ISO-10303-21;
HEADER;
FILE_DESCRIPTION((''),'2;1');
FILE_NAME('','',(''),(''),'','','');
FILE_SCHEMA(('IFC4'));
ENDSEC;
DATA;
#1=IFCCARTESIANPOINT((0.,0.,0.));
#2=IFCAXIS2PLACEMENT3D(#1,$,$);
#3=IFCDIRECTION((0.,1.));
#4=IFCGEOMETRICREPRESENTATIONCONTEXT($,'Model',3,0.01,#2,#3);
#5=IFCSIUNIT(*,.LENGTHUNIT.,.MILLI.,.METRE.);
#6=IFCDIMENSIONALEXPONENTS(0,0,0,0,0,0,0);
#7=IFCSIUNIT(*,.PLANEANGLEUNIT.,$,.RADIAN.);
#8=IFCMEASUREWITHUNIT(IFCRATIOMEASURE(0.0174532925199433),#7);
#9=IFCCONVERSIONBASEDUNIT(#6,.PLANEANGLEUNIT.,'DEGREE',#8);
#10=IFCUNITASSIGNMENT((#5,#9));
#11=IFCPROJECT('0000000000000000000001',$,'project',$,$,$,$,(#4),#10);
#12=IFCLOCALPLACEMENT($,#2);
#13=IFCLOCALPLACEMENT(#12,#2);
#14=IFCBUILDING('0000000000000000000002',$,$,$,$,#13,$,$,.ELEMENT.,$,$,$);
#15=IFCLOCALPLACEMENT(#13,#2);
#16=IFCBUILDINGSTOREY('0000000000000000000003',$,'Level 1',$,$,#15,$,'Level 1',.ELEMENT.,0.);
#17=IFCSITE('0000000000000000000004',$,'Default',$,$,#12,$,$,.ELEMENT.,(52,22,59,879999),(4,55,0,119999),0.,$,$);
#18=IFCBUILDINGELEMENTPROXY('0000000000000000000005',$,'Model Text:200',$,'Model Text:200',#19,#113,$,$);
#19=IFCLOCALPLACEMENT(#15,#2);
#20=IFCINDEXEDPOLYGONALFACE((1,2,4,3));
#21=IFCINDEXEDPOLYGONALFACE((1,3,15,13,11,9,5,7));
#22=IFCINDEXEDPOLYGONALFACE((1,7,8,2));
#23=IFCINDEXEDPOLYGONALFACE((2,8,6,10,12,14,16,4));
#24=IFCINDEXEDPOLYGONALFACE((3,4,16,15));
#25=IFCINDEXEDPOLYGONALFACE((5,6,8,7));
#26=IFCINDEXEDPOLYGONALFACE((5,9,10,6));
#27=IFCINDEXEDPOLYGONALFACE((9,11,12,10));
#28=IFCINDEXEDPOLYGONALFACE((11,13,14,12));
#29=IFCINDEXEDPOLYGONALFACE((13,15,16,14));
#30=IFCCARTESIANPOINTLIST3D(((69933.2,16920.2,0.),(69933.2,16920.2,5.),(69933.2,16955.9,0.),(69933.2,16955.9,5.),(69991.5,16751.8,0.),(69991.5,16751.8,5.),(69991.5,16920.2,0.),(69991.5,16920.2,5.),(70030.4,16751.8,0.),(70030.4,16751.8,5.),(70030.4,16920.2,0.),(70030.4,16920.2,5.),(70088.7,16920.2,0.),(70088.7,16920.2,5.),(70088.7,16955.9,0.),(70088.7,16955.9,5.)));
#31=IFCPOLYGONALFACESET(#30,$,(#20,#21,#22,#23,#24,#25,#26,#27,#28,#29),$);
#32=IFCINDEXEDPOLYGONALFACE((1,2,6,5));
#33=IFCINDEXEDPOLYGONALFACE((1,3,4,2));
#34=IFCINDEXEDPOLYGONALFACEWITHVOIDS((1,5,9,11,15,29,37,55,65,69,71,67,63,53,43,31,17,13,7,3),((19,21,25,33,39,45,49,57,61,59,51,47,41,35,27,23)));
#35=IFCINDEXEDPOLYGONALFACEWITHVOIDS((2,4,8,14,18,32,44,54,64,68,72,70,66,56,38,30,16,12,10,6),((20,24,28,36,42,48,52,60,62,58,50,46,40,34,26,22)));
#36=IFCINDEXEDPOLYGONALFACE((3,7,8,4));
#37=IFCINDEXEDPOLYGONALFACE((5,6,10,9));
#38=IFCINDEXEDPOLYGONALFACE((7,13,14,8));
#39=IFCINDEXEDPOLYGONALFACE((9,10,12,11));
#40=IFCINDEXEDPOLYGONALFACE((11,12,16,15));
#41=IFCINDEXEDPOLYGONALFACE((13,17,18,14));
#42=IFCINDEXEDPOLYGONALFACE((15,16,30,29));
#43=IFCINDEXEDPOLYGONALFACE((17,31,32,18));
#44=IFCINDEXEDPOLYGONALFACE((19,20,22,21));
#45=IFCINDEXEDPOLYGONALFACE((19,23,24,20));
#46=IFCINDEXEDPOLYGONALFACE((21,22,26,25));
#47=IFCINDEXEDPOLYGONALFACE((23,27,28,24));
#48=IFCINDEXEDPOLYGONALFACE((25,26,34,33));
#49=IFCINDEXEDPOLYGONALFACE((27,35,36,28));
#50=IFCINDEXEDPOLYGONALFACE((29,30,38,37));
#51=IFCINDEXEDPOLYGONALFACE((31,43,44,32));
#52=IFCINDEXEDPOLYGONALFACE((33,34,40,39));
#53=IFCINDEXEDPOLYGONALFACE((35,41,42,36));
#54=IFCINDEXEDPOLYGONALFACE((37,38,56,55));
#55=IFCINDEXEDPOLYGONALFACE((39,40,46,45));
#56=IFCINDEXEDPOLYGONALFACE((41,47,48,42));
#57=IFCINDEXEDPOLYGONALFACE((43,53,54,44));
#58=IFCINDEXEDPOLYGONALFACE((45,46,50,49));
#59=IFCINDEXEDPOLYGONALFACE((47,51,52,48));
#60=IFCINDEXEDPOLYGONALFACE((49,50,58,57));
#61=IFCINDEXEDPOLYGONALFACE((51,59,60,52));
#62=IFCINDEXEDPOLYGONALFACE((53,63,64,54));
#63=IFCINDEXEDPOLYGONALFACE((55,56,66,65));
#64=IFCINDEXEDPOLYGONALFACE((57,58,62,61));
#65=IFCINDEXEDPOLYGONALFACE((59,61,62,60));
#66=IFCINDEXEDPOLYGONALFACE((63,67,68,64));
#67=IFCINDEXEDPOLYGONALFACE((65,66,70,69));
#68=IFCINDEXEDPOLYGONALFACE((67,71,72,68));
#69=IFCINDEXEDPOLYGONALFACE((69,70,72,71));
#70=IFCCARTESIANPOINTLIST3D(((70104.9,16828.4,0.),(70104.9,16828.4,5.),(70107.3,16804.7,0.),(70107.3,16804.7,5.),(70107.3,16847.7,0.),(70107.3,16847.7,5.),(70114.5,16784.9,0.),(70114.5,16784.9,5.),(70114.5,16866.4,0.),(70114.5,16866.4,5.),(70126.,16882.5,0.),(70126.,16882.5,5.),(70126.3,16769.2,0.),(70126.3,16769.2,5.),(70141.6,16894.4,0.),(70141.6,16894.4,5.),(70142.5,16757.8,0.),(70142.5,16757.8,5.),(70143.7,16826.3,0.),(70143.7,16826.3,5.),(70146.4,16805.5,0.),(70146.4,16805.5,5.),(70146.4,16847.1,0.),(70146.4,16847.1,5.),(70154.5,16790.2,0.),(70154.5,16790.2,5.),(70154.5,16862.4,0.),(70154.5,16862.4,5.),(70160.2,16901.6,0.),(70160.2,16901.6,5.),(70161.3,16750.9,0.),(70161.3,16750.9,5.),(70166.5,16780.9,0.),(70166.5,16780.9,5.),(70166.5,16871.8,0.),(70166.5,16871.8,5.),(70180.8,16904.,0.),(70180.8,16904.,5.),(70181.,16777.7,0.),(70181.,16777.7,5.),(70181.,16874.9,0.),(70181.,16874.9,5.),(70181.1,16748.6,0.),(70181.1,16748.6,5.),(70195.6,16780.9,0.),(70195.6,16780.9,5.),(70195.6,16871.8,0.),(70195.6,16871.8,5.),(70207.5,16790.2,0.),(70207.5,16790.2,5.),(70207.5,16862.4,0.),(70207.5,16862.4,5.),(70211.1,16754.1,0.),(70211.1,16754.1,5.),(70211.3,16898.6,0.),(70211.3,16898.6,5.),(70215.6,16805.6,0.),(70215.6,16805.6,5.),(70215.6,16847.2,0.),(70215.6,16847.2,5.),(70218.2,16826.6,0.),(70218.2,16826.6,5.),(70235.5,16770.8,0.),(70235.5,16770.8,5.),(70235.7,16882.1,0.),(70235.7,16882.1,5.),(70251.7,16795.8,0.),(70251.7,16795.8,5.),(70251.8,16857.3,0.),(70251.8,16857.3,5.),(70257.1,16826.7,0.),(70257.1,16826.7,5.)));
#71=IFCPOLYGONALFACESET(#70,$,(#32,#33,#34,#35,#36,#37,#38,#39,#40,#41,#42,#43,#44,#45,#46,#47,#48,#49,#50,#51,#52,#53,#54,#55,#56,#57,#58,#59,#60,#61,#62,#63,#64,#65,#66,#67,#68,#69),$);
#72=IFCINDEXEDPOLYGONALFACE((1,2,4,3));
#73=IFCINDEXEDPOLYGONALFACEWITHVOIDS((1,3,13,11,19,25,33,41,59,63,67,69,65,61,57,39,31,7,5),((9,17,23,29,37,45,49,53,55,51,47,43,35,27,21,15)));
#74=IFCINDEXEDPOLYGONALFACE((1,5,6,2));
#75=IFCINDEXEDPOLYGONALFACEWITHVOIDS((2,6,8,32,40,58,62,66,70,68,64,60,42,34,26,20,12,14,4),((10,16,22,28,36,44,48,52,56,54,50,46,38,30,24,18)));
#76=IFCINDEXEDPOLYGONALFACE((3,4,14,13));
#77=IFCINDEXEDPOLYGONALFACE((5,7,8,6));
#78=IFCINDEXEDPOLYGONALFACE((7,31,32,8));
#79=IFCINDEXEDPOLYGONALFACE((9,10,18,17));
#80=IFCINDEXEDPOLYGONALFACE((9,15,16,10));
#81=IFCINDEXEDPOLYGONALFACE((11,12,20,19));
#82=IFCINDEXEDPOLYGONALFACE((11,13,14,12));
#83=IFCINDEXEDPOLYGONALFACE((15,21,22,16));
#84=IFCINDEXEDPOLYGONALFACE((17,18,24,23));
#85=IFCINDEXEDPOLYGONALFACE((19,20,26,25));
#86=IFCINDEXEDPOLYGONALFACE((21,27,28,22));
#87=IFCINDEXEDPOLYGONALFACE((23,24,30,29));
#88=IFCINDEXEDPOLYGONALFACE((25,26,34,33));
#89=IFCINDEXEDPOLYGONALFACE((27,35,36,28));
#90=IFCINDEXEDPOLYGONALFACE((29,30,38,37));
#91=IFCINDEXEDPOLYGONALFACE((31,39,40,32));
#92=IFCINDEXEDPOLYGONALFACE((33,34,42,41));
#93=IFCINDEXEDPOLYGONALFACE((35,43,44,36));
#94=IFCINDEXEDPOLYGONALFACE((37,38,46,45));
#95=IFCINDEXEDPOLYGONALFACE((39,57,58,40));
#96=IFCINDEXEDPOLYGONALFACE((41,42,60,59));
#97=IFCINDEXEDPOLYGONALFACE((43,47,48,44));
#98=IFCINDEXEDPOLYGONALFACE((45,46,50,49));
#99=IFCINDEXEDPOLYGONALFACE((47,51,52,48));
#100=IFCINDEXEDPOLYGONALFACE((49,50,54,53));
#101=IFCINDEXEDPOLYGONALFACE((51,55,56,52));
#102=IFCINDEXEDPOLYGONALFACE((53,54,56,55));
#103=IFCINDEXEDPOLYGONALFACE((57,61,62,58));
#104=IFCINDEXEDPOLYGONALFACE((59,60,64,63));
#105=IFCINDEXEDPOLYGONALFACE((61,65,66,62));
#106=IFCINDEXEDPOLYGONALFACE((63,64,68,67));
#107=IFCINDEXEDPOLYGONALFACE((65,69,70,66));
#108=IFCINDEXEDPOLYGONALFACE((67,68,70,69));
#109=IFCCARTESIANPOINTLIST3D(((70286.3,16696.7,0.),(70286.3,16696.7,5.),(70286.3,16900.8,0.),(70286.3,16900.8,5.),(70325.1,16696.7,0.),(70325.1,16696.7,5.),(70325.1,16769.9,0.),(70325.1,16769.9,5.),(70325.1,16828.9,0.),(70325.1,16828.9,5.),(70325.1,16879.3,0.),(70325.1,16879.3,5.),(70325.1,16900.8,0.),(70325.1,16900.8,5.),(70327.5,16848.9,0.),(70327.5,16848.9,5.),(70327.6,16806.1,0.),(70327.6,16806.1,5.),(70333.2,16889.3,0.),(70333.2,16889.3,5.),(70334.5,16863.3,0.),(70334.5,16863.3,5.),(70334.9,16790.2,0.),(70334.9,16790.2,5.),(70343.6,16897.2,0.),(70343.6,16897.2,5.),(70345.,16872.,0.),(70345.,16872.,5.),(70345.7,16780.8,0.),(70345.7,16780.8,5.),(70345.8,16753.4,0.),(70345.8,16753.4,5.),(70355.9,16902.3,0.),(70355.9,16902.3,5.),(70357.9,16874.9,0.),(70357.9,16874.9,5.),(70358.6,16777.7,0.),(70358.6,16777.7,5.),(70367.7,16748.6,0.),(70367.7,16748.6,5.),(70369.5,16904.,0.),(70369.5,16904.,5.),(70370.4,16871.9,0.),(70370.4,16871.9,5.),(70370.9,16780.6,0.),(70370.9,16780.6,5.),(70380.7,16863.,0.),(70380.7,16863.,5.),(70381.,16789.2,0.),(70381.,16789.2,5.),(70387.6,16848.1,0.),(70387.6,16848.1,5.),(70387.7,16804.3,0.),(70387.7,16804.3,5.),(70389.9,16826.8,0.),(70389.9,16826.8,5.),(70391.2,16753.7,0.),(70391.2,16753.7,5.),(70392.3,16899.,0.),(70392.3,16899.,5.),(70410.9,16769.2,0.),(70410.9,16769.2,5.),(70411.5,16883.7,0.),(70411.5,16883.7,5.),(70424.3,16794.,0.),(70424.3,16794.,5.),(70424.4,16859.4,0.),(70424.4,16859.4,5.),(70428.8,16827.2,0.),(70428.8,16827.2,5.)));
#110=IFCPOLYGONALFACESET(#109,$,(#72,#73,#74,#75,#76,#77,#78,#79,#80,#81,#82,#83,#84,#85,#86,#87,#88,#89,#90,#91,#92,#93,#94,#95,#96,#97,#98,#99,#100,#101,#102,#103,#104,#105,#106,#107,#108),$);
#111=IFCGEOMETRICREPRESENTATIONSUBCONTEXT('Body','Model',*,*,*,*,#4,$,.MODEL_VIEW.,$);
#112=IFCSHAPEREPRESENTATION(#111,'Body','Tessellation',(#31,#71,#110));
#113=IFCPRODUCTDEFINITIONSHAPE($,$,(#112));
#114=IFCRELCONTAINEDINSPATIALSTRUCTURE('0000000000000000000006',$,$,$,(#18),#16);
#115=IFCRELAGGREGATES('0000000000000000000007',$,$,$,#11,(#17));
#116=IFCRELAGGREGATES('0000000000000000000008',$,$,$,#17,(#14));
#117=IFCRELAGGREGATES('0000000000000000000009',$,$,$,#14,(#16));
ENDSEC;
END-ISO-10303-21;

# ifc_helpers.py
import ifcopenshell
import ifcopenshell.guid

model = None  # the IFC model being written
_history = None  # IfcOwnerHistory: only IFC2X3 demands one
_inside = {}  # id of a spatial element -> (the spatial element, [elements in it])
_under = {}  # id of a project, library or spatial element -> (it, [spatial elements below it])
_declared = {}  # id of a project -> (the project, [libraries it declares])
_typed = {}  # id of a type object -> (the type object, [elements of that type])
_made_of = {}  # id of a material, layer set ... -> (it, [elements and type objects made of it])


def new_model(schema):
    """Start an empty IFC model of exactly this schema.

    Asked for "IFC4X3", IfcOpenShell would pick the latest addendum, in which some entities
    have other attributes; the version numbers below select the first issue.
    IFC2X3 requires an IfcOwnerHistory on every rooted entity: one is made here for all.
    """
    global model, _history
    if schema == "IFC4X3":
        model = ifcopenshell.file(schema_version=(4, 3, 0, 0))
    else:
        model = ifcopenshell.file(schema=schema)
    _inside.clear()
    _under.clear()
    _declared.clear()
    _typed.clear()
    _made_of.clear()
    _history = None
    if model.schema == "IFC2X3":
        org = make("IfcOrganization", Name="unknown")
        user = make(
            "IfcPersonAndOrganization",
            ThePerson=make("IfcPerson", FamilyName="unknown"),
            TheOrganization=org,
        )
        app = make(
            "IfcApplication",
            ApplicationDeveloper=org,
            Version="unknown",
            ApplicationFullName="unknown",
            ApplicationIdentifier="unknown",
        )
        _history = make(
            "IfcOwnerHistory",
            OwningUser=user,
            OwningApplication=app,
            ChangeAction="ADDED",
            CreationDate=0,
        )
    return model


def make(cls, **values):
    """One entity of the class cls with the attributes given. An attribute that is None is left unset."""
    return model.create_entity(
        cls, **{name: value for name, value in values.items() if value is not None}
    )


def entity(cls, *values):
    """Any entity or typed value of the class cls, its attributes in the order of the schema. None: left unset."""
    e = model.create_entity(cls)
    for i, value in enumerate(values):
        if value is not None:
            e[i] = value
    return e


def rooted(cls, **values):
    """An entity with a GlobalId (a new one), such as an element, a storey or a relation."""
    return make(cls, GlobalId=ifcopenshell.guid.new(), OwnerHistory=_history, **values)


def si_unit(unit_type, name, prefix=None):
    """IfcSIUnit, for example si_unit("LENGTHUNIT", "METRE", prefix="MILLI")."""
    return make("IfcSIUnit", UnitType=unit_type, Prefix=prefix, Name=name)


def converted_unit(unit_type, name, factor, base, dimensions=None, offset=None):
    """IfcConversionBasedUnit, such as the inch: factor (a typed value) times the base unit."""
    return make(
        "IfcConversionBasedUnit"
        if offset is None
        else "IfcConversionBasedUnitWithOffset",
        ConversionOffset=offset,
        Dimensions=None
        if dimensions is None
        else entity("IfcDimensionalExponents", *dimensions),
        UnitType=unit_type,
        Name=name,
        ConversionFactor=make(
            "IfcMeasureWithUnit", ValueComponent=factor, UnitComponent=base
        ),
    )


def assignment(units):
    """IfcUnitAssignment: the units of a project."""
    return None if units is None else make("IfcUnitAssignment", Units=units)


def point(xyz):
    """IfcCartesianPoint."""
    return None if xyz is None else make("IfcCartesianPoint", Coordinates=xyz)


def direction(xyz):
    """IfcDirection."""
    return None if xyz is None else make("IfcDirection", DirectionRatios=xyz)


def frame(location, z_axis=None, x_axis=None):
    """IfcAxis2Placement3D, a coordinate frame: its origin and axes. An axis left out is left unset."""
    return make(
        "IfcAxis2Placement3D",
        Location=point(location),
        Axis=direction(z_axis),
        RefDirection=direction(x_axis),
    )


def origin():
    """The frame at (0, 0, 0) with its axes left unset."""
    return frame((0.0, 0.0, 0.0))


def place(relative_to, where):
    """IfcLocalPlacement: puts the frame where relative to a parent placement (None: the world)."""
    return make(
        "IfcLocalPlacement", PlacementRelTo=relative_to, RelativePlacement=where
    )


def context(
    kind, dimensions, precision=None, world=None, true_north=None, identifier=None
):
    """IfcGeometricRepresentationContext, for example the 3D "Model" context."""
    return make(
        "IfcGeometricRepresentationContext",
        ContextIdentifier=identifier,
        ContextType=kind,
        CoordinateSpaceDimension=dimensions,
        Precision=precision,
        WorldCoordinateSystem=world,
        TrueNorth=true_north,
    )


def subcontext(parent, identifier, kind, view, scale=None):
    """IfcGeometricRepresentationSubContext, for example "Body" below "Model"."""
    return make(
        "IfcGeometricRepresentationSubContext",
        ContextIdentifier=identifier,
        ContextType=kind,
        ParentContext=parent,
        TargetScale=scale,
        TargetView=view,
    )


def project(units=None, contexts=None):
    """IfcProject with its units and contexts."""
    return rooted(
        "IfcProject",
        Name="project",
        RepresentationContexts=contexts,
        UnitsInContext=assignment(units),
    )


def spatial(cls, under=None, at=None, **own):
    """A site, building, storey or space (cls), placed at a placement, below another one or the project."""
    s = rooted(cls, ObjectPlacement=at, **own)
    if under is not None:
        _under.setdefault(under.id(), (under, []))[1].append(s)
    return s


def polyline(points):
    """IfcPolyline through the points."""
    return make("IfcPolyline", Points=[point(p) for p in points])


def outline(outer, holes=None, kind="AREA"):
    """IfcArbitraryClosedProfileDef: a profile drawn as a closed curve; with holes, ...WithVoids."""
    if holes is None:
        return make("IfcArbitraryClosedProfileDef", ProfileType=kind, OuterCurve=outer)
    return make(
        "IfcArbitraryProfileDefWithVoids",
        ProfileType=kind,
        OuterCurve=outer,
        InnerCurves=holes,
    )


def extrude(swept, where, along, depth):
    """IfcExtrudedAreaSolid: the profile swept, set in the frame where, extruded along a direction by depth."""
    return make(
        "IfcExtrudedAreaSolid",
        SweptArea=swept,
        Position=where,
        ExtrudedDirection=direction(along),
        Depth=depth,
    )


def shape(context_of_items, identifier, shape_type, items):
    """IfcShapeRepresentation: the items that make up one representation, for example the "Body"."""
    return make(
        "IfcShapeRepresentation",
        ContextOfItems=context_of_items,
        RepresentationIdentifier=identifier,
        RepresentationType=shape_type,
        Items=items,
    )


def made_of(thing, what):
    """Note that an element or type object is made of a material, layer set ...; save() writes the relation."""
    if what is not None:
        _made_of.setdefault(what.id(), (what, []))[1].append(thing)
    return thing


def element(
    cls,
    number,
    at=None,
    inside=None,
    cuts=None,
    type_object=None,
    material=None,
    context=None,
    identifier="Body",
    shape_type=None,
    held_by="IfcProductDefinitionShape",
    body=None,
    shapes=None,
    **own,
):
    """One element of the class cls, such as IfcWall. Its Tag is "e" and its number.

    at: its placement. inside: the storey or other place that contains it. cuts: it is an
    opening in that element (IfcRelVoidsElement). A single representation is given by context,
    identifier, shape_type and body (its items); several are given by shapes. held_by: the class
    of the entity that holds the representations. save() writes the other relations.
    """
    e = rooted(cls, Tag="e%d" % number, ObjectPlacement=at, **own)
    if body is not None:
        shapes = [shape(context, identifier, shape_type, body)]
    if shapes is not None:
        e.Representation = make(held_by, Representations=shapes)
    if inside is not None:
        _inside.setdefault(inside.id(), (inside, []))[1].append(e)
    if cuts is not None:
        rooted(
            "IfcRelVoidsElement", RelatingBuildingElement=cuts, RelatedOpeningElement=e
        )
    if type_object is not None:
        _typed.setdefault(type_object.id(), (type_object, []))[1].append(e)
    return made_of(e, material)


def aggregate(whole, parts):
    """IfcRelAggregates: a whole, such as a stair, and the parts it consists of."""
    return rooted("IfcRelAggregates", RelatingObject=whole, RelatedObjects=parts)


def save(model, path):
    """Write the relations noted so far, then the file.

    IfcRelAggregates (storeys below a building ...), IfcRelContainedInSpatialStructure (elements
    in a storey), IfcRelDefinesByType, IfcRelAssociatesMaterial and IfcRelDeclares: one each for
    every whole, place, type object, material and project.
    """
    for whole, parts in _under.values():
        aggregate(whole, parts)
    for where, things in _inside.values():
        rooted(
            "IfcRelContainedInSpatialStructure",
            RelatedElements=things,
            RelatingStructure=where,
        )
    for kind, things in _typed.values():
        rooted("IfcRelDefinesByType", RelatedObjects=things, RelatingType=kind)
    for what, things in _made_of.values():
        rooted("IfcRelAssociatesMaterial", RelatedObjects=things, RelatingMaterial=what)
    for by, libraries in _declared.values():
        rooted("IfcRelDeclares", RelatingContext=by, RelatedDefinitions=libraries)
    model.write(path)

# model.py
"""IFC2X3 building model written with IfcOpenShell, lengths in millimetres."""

from ifc_helpers import new_model, entity, si_unit, converted_unit, direction, frame, origin, place, context, subcontext, project, spatial, polyline, outline, extrude, element, save


model = new_model("IFC2X3")

# Units and contexts
model_context = context("Model", 3, precision=0.01, world=origin(), true_north=direction((0.0, 1.0)))
body_context = subcontext(model_context, "Body", "Model", "MODEL_VIEW")
ifc_project = project(units=[si_unit("LENGTHUNIT", "METRE", prefix="MILLI"), converted_unit("PLANEANGLEUNIT", "DEGREE", entity("IfcRatioMeasure", 0.0174532925199433), si_unit("PLANEANGLEUNIT", "RADIAN"), dimensions=[0, 0, 0, 0, 0, 0, 0])], contexts=[model_context])

# Site, building, storey
site_placement = place(None, origin())
site = spatial("IfcSite", under=ifc_project, at=site_placement, Name="Default", CompositionType="ELEMENT", RefLatitude=(52, 22, 59, 879999), RefLongitude=(4, 55, 0, 119999), RefElevation=0.0)
building_placement = place(site_placement, origin())
building = spatial("IfcBuilding", under=site, at=building_placement, CompositionType="ELEMENT")
storey_placement = place(building_placement, origin())
storey = spatial("IfcBuildingStorey", under=building, at=storey_placement, Name="Level 1", LongName="Level 1", CompositionType="ELEMENT", Elevation=0.0)

# Building element proxy
proxy_1_placement = place(building_placement, origin())
element("IfcBuildingElementProxy", 1, at=proxy_1_placement, inside=storey, Name="Model Text:200", ObjectType="Model Text:200", context=body_context, shape_type="SweptSolid", body=[
    extrude(outline(polyline([(-19.4, -135.2), (19.4, -135.2), (19.4, 33.2), (77.7, 33.2), (77.7, 68.8), (-77.7, 68.8), (-77.7, 33.2), (-19.4, 33.2), (-19.4, -135.2)])), frame((70010.9, 16887.0, 0.0)), (0.0, 0.0, 1.0), 5.0),
    extrude(outline(polyline([(-8.8, -65.7), (15.1, -65.7), (35.5, -60.5), (52.3, -50.4), (65.3, -35.4), (74.1, -17.3), (78.4, 2.1), (75.9, 32.5), (61.8, 58.5), (38.4, 77.1), (8.3, 85.6), (-22.7, 83.3), (-49.0, 69.9), (-67.8, 47.3), (-76.3, 17.5), (-76.0, -3.3), (-70.7, -22.5), (-60.5, -39.2), (-45.5, -52.3), (-27.7, -61.4), (-8.8, -65.7)]), holes=[polyline([(-2.7, -27.2), (-23.1, -22.5), (-37.5, -12.9), (-45.7, 0.0), (-47.3, 14.8), (-42.7, 28.9), (-32.2, 39.9), (-16.3, 46.3), (4.5, 46.9), (25.1, 42.1), (39.6, 32.6), (47.7, 19.7), (49.4, 5.0), (44.8, -9.2), (34.2, -20.2), (18.2, -26.7), (-2.7, -27.2)])]), frame((70171.1, 16826.3, 0.0), z_axis=(0.0, 0.0, 1.0), x_axis=(0.100608, -0.994926, 0.0)), (0.0, 0.0, 1.0), 5.0),
    extrude(outline(polyline([(-73.1, -75.4), (130.9, -75.4), (130.9, -36.6), (57.8, -36.6), (74.3, -15.9), (79.1, 6.0), (73.9, 29.5), (58.4, 49.2), (33.6, 62.6), (0.5, 67.1), (-31.8, 62.8), (-56.1, 49.8), (-71.3, 30.7), (-76.4, 7.8), (-74.7, -5.8), (-69.6, -18.1), (-61.7, -28.5), (-51.7, -36.6), (-73.1, -36.6), (-73.1, -75.4)]), holes=[polyline([(-1.2, -36.6), (-21.2, -34.2), (-35.6, -27.2), (-44.3, -16.7), (-47.2, -3.8), (-44.3, 8.7), (-35.4, 19.0), (-20.4, 25.9), (0.8, 28.2), (23.3, 26.0), (38.5, 19.3), (47.1, 9.2), (49.9, -3.1), (46.8, -16.0), (37.4, -26.8), (21.5, -34.1), (-1.2, -36.6)])]), frame((70361.7, 16827.7, 0.0), z_axis=(0.0, 0.0, 1.0), x_axis=(0.0, -1.0, 0.0)), (0.0, 0.0, 1.0), 5.0),
])

save(model, "model.ifc")
